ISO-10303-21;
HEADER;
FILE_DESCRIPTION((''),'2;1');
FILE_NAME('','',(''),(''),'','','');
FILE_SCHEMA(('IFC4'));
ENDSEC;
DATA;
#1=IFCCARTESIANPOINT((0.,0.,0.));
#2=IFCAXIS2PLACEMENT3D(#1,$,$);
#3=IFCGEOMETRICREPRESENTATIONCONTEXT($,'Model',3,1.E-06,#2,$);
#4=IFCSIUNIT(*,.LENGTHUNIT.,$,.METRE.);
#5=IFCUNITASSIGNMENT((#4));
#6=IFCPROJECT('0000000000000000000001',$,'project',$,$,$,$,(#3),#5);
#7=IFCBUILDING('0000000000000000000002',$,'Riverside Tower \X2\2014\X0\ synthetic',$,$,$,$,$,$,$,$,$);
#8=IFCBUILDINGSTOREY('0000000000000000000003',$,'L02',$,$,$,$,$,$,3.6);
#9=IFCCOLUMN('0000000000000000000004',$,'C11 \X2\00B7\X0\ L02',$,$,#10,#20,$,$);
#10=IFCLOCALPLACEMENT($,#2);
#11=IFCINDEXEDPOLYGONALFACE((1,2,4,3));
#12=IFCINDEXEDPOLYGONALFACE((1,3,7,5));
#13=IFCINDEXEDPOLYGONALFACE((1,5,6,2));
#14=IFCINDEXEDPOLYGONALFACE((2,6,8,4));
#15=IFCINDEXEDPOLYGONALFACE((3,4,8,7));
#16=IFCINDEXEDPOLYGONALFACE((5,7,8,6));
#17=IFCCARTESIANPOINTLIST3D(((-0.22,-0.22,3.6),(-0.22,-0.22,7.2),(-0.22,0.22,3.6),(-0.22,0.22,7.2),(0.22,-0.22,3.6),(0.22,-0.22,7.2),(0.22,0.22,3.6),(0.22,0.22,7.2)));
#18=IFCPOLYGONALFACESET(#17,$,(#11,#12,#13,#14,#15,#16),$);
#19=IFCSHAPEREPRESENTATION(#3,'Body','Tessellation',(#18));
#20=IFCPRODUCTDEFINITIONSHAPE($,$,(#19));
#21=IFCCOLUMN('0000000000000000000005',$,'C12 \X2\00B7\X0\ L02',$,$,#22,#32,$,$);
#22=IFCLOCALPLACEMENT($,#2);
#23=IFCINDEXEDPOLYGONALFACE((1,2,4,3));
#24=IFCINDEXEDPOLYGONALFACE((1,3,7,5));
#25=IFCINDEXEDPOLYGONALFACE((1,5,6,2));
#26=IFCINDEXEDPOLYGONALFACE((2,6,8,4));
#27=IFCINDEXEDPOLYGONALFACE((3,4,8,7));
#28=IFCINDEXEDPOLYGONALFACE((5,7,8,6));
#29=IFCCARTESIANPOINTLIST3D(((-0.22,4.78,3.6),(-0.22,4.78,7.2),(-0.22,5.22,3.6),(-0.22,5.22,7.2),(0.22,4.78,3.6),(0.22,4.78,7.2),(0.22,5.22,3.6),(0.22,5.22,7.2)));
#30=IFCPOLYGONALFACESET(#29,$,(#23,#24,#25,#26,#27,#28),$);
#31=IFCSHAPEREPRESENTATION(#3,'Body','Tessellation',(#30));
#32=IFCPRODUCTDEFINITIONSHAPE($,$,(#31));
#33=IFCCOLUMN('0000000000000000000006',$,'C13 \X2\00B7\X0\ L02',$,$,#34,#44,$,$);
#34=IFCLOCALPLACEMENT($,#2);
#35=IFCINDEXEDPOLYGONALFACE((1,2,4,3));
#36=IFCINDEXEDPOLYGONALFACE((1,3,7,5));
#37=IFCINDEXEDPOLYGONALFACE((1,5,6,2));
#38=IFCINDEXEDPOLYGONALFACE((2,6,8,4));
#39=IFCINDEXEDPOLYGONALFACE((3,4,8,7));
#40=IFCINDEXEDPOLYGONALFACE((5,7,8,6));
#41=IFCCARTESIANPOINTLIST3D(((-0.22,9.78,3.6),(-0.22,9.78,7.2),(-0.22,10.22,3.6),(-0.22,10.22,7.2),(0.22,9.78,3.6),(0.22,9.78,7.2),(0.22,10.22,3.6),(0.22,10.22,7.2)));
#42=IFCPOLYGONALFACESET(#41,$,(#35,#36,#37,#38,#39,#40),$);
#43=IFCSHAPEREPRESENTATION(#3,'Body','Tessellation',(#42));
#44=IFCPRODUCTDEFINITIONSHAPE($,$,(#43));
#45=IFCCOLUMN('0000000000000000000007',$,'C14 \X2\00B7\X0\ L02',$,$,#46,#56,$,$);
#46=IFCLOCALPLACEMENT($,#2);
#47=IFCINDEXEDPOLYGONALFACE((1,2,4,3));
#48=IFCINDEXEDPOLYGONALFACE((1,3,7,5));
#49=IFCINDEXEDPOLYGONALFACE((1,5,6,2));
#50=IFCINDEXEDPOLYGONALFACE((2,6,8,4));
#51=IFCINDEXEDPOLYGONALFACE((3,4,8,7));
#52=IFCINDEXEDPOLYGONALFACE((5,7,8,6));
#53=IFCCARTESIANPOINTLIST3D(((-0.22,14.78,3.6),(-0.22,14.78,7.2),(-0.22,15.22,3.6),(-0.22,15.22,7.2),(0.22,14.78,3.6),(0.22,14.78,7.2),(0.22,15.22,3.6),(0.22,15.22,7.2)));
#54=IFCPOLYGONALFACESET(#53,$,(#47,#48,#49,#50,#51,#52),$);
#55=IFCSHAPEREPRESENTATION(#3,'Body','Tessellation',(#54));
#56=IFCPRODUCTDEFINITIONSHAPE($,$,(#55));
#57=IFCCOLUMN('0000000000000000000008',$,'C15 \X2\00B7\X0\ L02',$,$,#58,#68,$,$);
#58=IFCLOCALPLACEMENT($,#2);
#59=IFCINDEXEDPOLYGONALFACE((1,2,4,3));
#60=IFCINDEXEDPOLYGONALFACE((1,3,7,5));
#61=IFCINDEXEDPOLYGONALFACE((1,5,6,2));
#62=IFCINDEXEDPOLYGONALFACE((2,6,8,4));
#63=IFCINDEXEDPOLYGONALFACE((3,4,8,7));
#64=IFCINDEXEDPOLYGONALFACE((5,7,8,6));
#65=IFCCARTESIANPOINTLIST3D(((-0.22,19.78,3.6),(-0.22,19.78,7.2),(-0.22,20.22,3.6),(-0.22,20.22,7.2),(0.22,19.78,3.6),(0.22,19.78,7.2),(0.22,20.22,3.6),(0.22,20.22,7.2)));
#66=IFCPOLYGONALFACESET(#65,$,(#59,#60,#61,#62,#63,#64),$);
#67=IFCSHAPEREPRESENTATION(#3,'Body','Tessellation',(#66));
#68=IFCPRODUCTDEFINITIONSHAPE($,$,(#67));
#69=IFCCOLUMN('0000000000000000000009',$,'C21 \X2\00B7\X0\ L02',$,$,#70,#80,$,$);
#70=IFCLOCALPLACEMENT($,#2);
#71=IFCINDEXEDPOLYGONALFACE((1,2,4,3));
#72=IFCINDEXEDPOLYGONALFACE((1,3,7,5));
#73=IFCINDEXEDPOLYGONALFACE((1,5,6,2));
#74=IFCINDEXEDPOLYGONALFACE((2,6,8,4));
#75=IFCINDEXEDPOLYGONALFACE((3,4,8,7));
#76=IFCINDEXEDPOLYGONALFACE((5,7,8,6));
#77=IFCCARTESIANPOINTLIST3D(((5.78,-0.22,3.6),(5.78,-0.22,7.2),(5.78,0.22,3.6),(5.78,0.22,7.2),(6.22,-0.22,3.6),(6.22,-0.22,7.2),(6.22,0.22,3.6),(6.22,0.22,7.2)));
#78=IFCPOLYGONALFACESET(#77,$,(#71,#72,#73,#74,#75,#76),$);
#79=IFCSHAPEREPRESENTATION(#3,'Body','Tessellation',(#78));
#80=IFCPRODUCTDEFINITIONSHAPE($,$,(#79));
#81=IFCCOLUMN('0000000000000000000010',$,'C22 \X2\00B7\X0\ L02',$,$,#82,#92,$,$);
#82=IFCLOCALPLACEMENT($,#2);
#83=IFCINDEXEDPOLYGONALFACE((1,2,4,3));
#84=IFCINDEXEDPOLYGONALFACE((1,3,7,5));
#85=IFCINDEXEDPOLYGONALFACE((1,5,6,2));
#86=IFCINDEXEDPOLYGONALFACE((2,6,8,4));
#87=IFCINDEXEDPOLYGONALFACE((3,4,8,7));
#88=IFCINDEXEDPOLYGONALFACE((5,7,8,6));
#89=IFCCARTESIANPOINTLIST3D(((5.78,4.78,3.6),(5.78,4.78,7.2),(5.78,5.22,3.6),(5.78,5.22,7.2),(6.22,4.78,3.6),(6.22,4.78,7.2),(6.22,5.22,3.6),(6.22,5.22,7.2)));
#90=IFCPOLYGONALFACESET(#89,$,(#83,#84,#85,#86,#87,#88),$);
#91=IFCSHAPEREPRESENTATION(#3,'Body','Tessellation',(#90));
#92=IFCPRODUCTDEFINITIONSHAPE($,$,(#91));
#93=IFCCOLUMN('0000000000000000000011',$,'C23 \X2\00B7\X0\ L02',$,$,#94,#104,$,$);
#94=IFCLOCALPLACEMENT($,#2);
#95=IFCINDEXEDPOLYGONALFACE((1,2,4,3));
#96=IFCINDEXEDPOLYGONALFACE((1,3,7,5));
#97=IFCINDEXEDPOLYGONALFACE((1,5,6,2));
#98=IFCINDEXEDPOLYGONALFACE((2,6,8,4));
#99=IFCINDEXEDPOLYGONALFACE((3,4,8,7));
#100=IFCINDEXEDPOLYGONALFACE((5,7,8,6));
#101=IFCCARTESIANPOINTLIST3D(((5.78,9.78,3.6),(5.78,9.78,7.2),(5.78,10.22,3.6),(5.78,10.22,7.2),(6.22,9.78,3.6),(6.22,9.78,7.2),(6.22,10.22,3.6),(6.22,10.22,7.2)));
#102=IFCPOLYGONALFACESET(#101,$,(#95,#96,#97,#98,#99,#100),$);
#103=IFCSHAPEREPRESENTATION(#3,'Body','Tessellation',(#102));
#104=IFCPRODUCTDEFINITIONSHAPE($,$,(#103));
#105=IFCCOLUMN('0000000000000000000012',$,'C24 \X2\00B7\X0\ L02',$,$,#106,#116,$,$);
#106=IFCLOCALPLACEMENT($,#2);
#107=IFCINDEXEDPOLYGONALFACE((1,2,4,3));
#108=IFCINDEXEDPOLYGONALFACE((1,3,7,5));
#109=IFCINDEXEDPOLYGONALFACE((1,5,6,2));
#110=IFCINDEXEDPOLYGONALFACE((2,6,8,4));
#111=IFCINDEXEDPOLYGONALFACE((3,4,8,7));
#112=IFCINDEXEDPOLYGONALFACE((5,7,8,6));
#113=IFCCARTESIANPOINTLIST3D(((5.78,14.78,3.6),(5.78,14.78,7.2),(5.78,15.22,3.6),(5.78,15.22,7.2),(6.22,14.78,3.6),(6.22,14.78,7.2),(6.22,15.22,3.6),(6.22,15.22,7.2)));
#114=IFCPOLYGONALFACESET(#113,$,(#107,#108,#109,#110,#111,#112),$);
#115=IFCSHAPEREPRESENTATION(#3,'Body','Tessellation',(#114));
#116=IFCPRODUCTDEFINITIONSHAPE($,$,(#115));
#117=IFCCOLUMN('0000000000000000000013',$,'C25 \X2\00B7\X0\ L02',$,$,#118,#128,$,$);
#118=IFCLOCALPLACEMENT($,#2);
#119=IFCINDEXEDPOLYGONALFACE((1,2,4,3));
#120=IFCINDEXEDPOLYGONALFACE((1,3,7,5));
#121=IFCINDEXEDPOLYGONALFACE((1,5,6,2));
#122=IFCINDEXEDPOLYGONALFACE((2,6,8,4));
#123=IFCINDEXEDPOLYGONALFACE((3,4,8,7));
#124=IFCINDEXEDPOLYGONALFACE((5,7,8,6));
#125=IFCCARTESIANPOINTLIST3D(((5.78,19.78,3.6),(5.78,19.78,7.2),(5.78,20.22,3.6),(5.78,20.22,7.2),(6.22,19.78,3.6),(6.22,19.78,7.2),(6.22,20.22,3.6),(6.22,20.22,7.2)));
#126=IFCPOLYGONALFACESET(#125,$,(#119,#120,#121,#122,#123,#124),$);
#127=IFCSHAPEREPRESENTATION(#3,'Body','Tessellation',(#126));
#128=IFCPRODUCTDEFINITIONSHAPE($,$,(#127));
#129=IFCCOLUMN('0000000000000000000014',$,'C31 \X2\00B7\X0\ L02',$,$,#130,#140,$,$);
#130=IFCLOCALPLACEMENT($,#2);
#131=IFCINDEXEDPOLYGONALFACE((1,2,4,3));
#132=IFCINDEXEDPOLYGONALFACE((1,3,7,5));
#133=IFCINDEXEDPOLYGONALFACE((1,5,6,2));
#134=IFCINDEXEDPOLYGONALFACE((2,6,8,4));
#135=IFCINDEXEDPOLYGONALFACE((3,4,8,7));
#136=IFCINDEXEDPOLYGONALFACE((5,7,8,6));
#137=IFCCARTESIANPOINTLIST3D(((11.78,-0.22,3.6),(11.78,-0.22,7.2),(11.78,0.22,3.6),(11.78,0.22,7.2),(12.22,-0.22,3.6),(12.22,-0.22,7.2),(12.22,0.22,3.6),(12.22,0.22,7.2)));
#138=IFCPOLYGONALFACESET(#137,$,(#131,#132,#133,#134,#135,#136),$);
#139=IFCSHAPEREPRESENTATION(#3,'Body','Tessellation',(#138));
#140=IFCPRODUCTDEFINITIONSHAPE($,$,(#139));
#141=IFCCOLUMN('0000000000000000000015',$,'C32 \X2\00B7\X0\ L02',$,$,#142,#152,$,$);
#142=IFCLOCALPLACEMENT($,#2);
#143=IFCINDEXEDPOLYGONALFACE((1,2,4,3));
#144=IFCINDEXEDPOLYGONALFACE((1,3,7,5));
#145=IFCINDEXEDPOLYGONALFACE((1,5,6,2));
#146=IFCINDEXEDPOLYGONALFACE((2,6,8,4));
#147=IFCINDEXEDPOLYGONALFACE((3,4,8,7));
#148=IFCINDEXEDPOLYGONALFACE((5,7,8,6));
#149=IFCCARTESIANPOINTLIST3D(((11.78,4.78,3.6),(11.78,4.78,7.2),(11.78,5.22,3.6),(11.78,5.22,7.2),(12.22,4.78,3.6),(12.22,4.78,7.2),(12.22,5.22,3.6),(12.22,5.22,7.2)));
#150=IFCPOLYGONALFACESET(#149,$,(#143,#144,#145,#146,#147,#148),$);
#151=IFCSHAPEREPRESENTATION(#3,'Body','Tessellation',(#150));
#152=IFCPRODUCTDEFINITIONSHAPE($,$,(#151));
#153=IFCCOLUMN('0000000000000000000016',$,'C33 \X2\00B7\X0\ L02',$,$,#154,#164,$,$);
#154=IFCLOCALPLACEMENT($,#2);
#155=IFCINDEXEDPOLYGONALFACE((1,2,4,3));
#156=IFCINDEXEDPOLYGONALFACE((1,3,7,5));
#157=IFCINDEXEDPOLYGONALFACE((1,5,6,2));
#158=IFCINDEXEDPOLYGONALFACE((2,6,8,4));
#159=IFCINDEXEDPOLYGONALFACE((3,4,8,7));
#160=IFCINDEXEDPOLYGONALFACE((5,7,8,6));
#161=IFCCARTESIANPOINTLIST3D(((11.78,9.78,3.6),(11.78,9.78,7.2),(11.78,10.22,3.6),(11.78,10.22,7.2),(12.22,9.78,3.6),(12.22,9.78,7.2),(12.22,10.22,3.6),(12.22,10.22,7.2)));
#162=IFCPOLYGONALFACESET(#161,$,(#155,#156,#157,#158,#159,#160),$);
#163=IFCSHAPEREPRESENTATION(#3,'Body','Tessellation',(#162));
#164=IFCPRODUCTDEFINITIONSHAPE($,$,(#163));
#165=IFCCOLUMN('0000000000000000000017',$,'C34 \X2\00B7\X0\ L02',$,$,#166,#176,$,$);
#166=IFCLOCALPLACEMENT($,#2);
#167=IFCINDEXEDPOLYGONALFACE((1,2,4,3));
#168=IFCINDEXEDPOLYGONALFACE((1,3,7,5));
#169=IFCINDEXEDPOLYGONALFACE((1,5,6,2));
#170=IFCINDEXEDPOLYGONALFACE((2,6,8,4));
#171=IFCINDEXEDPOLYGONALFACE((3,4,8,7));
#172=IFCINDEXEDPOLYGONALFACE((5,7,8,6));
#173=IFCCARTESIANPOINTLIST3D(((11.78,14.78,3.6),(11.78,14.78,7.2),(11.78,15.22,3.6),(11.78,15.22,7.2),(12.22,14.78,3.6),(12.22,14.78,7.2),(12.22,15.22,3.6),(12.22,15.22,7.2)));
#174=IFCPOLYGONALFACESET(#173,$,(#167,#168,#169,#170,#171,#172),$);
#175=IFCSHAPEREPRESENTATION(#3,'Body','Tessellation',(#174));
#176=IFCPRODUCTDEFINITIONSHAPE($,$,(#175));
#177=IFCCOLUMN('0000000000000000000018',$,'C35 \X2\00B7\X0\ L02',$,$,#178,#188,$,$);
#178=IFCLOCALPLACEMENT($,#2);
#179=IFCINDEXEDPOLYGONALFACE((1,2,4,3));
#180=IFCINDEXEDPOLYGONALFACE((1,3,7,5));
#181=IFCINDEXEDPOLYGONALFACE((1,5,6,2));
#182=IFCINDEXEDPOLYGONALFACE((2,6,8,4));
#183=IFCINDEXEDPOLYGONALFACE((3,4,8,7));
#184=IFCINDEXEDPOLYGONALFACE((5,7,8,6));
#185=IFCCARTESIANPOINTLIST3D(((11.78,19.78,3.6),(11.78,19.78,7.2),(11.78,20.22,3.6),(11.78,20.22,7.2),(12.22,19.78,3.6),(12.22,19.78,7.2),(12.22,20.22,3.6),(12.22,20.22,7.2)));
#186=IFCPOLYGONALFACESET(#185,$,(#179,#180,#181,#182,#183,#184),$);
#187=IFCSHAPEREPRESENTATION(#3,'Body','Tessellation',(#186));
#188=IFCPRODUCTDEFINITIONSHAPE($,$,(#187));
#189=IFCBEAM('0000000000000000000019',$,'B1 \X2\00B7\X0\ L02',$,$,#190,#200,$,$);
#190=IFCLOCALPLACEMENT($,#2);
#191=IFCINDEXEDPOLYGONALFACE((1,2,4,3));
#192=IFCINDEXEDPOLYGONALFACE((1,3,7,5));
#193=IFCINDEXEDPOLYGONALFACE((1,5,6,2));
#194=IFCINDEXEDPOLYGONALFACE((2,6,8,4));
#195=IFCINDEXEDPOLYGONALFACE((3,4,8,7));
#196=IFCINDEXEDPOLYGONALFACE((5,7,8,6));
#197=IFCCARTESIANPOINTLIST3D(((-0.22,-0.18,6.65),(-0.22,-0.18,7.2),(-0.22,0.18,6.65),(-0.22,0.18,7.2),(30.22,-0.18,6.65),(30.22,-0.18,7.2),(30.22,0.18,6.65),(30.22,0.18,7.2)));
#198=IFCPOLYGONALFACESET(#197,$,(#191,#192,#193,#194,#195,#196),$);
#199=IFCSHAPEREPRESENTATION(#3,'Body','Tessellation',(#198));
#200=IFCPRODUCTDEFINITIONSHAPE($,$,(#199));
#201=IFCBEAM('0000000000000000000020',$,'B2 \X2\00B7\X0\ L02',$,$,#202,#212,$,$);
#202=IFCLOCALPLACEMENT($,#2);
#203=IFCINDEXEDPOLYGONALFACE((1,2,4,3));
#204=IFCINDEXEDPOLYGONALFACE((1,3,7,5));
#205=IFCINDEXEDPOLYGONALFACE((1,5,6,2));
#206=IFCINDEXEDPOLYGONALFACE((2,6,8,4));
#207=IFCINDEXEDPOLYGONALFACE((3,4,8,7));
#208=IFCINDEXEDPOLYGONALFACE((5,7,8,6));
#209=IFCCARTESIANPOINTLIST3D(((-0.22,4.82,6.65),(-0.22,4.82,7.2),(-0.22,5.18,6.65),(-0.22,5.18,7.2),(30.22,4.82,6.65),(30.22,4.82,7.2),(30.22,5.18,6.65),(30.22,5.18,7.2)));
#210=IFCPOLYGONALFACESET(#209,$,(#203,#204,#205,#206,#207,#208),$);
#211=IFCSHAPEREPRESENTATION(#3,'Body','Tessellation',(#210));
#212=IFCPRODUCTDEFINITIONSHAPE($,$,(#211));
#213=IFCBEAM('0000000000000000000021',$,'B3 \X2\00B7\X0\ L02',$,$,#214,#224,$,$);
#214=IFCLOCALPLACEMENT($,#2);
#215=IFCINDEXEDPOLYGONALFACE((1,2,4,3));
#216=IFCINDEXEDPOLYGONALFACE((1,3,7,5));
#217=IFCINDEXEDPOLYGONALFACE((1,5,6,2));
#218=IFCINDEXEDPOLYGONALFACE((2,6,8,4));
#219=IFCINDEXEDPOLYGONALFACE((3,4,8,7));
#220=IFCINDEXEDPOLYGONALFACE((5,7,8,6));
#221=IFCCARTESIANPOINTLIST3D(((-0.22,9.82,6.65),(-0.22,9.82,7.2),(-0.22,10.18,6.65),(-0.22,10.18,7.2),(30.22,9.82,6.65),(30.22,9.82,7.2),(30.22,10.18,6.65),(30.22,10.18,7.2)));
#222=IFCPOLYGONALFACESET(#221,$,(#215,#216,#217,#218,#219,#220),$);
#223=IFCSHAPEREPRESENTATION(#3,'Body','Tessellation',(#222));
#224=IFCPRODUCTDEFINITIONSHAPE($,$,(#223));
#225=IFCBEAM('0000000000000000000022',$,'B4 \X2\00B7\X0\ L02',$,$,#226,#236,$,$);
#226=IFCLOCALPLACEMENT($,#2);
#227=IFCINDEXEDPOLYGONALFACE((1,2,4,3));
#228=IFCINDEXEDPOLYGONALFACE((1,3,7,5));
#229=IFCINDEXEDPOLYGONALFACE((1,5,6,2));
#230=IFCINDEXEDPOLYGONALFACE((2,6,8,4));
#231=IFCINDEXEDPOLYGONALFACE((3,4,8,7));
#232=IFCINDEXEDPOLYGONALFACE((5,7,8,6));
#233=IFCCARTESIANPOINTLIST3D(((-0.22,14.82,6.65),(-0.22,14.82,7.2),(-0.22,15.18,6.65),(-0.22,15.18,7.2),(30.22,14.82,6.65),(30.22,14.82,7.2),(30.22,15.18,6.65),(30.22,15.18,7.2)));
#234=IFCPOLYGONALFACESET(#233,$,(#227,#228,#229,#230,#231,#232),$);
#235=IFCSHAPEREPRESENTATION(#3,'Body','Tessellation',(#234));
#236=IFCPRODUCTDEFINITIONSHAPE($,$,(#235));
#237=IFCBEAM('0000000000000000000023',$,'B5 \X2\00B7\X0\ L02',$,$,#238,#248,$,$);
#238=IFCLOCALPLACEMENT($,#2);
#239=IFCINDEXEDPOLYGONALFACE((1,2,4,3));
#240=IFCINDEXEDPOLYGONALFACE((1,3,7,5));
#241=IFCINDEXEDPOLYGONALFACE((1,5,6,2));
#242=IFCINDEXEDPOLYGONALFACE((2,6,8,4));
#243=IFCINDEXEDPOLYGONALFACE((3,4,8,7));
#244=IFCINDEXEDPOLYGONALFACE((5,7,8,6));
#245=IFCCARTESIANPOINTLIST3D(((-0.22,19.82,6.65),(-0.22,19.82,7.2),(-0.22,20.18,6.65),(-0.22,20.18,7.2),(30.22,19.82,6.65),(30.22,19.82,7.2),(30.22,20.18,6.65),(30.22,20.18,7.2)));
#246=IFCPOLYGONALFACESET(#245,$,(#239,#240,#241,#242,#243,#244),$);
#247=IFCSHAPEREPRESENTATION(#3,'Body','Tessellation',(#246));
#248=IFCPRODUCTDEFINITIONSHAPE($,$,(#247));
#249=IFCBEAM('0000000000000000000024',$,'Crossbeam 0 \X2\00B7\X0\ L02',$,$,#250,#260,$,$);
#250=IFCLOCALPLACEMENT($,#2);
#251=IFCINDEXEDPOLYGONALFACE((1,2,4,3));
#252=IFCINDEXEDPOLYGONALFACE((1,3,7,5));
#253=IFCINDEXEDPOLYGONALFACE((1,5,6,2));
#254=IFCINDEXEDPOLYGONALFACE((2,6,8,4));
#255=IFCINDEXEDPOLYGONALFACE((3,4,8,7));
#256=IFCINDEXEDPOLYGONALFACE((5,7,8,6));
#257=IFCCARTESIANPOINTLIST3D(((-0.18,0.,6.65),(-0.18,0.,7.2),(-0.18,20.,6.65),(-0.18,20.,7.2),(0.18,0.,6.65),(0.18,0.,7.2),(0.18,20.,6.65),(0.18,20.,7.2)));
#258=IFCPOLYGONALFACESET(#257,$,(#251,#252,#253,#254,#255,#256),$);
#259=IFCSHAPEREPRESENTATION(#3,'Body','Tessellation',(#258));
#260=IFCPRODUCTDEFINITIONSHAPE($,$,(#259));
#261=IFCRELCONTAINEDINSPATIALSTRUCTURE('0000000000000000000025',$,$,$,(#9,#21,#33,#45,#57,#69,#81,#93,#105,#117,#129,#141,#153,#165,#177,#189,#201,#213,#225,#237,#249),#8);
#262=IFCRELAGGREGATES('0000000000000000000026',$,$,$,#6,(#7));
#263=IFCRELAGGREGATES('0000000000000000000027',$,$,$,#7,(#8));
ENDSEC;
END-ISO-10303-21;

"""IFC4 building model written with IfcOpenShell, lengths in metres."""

from ifc_helpers import new_model, si_unit, frame, origin, place, context, project, spatial, rectangle, extrude, element, save


model = new_model("IFC4")

# Units and contexts
model_context = context("Model", 3, precision=1e-06, world=origin())
ifc_project = project(units=[si_unit("LENGTHUNIT", "METRE")], contexts=[model_context])

# Building, storey
building = spatial("IfcBuilding", under=ifc_project, Name="Riverside Tower — synthetic")
storey = spatial("IfcBuildingStorey", under=building, Name="L02", Elevation=3.6)

# Columns
for number, where, name in (
    (1, (0.0, 0.0, 3.6), "C11 · L02"),
    (2, (0.0, 5.0, 3.6), "C12 · L02"),
    (3, (0.0, 10.0, 3.6), "C13 · L02"),
    (4, (0.0, 15.0, 3.6), "C14 · L02"),
    (5, (0.0, 20.0, 3.6), "C15 · L02"),
    (6, (6.0, 0.0, 3.6), "C21 · L02"),
    (7, (6.0, 5.0, 3.6), "C22 · L02"),
    (8, (6.0, 10.0, 3.6), "C23 · L02"),
    (9, (6.0, 15.0, 3.6), "C24 · L02"),
    (10, (6.0, 20.0, 3.6), "C25 · L02"),
    (11, (12.0, 0.0, 3.6), "C31 · L02"),
    (12, (12.0, 5.0, 3.6), "C32 · L02"),
    (13, (12.0, 10.0, 3.6), "C33 · L02"),
    (14, (12.0, 15.0, 3.6), "C34 · L02"),
    (15, (12.0, 20.0, 3.6), "C35 · L02"),
):
    element("IfcColumn", number, at=place(None, frame(where)), inside=storey, Name=name, context=model_context, shape_type="SweptSolid", body=[
        extrude(rectangle(XDim=0.44, YDim=0.44), origin(), (0.0, 0.0, 1.0), 3.6),
    ])

# Beams
for number, where, name in (
    (16, (15.0, 0.0, 6.65), "B1 · L02"),
    (17, (15.0, 5.0, 6.65), "B2 · L02"),
    (18, (15.0, 10.0, 6.65), "B3 · L02"),
    (19, (15.0, 15.0, 6.65), "B4 · L02"),
    (20, (15.0, 20.0, 6.65), "B5 · L02"),
):
    element("IfcBeam", number, at=place(None, frame(where)), inside=storey, Name=name, context=model_context, shape_type="SweptSolid", body=[
        extrude(rectangle(XDim=30.44, YDim=0.36), origin(), (0.0, 0.0, 1.0), 0.55),
    ])
for number, where, name in (
    (21, (0.0, 10.0, 6.65), "Crossbeam 0 · L02"),
):
    element("IfcBeam", number, at=place(None, frame(where)), inside=storey, Name=name, context=model_context, shape_type="SweptSolid", body=[
        extrude(rectangle(XDim=0.36, YDim=20.0), origin(), (0.0, 0.0, 1.0), 0.55),
    ])

save(model, "model.ifc")
